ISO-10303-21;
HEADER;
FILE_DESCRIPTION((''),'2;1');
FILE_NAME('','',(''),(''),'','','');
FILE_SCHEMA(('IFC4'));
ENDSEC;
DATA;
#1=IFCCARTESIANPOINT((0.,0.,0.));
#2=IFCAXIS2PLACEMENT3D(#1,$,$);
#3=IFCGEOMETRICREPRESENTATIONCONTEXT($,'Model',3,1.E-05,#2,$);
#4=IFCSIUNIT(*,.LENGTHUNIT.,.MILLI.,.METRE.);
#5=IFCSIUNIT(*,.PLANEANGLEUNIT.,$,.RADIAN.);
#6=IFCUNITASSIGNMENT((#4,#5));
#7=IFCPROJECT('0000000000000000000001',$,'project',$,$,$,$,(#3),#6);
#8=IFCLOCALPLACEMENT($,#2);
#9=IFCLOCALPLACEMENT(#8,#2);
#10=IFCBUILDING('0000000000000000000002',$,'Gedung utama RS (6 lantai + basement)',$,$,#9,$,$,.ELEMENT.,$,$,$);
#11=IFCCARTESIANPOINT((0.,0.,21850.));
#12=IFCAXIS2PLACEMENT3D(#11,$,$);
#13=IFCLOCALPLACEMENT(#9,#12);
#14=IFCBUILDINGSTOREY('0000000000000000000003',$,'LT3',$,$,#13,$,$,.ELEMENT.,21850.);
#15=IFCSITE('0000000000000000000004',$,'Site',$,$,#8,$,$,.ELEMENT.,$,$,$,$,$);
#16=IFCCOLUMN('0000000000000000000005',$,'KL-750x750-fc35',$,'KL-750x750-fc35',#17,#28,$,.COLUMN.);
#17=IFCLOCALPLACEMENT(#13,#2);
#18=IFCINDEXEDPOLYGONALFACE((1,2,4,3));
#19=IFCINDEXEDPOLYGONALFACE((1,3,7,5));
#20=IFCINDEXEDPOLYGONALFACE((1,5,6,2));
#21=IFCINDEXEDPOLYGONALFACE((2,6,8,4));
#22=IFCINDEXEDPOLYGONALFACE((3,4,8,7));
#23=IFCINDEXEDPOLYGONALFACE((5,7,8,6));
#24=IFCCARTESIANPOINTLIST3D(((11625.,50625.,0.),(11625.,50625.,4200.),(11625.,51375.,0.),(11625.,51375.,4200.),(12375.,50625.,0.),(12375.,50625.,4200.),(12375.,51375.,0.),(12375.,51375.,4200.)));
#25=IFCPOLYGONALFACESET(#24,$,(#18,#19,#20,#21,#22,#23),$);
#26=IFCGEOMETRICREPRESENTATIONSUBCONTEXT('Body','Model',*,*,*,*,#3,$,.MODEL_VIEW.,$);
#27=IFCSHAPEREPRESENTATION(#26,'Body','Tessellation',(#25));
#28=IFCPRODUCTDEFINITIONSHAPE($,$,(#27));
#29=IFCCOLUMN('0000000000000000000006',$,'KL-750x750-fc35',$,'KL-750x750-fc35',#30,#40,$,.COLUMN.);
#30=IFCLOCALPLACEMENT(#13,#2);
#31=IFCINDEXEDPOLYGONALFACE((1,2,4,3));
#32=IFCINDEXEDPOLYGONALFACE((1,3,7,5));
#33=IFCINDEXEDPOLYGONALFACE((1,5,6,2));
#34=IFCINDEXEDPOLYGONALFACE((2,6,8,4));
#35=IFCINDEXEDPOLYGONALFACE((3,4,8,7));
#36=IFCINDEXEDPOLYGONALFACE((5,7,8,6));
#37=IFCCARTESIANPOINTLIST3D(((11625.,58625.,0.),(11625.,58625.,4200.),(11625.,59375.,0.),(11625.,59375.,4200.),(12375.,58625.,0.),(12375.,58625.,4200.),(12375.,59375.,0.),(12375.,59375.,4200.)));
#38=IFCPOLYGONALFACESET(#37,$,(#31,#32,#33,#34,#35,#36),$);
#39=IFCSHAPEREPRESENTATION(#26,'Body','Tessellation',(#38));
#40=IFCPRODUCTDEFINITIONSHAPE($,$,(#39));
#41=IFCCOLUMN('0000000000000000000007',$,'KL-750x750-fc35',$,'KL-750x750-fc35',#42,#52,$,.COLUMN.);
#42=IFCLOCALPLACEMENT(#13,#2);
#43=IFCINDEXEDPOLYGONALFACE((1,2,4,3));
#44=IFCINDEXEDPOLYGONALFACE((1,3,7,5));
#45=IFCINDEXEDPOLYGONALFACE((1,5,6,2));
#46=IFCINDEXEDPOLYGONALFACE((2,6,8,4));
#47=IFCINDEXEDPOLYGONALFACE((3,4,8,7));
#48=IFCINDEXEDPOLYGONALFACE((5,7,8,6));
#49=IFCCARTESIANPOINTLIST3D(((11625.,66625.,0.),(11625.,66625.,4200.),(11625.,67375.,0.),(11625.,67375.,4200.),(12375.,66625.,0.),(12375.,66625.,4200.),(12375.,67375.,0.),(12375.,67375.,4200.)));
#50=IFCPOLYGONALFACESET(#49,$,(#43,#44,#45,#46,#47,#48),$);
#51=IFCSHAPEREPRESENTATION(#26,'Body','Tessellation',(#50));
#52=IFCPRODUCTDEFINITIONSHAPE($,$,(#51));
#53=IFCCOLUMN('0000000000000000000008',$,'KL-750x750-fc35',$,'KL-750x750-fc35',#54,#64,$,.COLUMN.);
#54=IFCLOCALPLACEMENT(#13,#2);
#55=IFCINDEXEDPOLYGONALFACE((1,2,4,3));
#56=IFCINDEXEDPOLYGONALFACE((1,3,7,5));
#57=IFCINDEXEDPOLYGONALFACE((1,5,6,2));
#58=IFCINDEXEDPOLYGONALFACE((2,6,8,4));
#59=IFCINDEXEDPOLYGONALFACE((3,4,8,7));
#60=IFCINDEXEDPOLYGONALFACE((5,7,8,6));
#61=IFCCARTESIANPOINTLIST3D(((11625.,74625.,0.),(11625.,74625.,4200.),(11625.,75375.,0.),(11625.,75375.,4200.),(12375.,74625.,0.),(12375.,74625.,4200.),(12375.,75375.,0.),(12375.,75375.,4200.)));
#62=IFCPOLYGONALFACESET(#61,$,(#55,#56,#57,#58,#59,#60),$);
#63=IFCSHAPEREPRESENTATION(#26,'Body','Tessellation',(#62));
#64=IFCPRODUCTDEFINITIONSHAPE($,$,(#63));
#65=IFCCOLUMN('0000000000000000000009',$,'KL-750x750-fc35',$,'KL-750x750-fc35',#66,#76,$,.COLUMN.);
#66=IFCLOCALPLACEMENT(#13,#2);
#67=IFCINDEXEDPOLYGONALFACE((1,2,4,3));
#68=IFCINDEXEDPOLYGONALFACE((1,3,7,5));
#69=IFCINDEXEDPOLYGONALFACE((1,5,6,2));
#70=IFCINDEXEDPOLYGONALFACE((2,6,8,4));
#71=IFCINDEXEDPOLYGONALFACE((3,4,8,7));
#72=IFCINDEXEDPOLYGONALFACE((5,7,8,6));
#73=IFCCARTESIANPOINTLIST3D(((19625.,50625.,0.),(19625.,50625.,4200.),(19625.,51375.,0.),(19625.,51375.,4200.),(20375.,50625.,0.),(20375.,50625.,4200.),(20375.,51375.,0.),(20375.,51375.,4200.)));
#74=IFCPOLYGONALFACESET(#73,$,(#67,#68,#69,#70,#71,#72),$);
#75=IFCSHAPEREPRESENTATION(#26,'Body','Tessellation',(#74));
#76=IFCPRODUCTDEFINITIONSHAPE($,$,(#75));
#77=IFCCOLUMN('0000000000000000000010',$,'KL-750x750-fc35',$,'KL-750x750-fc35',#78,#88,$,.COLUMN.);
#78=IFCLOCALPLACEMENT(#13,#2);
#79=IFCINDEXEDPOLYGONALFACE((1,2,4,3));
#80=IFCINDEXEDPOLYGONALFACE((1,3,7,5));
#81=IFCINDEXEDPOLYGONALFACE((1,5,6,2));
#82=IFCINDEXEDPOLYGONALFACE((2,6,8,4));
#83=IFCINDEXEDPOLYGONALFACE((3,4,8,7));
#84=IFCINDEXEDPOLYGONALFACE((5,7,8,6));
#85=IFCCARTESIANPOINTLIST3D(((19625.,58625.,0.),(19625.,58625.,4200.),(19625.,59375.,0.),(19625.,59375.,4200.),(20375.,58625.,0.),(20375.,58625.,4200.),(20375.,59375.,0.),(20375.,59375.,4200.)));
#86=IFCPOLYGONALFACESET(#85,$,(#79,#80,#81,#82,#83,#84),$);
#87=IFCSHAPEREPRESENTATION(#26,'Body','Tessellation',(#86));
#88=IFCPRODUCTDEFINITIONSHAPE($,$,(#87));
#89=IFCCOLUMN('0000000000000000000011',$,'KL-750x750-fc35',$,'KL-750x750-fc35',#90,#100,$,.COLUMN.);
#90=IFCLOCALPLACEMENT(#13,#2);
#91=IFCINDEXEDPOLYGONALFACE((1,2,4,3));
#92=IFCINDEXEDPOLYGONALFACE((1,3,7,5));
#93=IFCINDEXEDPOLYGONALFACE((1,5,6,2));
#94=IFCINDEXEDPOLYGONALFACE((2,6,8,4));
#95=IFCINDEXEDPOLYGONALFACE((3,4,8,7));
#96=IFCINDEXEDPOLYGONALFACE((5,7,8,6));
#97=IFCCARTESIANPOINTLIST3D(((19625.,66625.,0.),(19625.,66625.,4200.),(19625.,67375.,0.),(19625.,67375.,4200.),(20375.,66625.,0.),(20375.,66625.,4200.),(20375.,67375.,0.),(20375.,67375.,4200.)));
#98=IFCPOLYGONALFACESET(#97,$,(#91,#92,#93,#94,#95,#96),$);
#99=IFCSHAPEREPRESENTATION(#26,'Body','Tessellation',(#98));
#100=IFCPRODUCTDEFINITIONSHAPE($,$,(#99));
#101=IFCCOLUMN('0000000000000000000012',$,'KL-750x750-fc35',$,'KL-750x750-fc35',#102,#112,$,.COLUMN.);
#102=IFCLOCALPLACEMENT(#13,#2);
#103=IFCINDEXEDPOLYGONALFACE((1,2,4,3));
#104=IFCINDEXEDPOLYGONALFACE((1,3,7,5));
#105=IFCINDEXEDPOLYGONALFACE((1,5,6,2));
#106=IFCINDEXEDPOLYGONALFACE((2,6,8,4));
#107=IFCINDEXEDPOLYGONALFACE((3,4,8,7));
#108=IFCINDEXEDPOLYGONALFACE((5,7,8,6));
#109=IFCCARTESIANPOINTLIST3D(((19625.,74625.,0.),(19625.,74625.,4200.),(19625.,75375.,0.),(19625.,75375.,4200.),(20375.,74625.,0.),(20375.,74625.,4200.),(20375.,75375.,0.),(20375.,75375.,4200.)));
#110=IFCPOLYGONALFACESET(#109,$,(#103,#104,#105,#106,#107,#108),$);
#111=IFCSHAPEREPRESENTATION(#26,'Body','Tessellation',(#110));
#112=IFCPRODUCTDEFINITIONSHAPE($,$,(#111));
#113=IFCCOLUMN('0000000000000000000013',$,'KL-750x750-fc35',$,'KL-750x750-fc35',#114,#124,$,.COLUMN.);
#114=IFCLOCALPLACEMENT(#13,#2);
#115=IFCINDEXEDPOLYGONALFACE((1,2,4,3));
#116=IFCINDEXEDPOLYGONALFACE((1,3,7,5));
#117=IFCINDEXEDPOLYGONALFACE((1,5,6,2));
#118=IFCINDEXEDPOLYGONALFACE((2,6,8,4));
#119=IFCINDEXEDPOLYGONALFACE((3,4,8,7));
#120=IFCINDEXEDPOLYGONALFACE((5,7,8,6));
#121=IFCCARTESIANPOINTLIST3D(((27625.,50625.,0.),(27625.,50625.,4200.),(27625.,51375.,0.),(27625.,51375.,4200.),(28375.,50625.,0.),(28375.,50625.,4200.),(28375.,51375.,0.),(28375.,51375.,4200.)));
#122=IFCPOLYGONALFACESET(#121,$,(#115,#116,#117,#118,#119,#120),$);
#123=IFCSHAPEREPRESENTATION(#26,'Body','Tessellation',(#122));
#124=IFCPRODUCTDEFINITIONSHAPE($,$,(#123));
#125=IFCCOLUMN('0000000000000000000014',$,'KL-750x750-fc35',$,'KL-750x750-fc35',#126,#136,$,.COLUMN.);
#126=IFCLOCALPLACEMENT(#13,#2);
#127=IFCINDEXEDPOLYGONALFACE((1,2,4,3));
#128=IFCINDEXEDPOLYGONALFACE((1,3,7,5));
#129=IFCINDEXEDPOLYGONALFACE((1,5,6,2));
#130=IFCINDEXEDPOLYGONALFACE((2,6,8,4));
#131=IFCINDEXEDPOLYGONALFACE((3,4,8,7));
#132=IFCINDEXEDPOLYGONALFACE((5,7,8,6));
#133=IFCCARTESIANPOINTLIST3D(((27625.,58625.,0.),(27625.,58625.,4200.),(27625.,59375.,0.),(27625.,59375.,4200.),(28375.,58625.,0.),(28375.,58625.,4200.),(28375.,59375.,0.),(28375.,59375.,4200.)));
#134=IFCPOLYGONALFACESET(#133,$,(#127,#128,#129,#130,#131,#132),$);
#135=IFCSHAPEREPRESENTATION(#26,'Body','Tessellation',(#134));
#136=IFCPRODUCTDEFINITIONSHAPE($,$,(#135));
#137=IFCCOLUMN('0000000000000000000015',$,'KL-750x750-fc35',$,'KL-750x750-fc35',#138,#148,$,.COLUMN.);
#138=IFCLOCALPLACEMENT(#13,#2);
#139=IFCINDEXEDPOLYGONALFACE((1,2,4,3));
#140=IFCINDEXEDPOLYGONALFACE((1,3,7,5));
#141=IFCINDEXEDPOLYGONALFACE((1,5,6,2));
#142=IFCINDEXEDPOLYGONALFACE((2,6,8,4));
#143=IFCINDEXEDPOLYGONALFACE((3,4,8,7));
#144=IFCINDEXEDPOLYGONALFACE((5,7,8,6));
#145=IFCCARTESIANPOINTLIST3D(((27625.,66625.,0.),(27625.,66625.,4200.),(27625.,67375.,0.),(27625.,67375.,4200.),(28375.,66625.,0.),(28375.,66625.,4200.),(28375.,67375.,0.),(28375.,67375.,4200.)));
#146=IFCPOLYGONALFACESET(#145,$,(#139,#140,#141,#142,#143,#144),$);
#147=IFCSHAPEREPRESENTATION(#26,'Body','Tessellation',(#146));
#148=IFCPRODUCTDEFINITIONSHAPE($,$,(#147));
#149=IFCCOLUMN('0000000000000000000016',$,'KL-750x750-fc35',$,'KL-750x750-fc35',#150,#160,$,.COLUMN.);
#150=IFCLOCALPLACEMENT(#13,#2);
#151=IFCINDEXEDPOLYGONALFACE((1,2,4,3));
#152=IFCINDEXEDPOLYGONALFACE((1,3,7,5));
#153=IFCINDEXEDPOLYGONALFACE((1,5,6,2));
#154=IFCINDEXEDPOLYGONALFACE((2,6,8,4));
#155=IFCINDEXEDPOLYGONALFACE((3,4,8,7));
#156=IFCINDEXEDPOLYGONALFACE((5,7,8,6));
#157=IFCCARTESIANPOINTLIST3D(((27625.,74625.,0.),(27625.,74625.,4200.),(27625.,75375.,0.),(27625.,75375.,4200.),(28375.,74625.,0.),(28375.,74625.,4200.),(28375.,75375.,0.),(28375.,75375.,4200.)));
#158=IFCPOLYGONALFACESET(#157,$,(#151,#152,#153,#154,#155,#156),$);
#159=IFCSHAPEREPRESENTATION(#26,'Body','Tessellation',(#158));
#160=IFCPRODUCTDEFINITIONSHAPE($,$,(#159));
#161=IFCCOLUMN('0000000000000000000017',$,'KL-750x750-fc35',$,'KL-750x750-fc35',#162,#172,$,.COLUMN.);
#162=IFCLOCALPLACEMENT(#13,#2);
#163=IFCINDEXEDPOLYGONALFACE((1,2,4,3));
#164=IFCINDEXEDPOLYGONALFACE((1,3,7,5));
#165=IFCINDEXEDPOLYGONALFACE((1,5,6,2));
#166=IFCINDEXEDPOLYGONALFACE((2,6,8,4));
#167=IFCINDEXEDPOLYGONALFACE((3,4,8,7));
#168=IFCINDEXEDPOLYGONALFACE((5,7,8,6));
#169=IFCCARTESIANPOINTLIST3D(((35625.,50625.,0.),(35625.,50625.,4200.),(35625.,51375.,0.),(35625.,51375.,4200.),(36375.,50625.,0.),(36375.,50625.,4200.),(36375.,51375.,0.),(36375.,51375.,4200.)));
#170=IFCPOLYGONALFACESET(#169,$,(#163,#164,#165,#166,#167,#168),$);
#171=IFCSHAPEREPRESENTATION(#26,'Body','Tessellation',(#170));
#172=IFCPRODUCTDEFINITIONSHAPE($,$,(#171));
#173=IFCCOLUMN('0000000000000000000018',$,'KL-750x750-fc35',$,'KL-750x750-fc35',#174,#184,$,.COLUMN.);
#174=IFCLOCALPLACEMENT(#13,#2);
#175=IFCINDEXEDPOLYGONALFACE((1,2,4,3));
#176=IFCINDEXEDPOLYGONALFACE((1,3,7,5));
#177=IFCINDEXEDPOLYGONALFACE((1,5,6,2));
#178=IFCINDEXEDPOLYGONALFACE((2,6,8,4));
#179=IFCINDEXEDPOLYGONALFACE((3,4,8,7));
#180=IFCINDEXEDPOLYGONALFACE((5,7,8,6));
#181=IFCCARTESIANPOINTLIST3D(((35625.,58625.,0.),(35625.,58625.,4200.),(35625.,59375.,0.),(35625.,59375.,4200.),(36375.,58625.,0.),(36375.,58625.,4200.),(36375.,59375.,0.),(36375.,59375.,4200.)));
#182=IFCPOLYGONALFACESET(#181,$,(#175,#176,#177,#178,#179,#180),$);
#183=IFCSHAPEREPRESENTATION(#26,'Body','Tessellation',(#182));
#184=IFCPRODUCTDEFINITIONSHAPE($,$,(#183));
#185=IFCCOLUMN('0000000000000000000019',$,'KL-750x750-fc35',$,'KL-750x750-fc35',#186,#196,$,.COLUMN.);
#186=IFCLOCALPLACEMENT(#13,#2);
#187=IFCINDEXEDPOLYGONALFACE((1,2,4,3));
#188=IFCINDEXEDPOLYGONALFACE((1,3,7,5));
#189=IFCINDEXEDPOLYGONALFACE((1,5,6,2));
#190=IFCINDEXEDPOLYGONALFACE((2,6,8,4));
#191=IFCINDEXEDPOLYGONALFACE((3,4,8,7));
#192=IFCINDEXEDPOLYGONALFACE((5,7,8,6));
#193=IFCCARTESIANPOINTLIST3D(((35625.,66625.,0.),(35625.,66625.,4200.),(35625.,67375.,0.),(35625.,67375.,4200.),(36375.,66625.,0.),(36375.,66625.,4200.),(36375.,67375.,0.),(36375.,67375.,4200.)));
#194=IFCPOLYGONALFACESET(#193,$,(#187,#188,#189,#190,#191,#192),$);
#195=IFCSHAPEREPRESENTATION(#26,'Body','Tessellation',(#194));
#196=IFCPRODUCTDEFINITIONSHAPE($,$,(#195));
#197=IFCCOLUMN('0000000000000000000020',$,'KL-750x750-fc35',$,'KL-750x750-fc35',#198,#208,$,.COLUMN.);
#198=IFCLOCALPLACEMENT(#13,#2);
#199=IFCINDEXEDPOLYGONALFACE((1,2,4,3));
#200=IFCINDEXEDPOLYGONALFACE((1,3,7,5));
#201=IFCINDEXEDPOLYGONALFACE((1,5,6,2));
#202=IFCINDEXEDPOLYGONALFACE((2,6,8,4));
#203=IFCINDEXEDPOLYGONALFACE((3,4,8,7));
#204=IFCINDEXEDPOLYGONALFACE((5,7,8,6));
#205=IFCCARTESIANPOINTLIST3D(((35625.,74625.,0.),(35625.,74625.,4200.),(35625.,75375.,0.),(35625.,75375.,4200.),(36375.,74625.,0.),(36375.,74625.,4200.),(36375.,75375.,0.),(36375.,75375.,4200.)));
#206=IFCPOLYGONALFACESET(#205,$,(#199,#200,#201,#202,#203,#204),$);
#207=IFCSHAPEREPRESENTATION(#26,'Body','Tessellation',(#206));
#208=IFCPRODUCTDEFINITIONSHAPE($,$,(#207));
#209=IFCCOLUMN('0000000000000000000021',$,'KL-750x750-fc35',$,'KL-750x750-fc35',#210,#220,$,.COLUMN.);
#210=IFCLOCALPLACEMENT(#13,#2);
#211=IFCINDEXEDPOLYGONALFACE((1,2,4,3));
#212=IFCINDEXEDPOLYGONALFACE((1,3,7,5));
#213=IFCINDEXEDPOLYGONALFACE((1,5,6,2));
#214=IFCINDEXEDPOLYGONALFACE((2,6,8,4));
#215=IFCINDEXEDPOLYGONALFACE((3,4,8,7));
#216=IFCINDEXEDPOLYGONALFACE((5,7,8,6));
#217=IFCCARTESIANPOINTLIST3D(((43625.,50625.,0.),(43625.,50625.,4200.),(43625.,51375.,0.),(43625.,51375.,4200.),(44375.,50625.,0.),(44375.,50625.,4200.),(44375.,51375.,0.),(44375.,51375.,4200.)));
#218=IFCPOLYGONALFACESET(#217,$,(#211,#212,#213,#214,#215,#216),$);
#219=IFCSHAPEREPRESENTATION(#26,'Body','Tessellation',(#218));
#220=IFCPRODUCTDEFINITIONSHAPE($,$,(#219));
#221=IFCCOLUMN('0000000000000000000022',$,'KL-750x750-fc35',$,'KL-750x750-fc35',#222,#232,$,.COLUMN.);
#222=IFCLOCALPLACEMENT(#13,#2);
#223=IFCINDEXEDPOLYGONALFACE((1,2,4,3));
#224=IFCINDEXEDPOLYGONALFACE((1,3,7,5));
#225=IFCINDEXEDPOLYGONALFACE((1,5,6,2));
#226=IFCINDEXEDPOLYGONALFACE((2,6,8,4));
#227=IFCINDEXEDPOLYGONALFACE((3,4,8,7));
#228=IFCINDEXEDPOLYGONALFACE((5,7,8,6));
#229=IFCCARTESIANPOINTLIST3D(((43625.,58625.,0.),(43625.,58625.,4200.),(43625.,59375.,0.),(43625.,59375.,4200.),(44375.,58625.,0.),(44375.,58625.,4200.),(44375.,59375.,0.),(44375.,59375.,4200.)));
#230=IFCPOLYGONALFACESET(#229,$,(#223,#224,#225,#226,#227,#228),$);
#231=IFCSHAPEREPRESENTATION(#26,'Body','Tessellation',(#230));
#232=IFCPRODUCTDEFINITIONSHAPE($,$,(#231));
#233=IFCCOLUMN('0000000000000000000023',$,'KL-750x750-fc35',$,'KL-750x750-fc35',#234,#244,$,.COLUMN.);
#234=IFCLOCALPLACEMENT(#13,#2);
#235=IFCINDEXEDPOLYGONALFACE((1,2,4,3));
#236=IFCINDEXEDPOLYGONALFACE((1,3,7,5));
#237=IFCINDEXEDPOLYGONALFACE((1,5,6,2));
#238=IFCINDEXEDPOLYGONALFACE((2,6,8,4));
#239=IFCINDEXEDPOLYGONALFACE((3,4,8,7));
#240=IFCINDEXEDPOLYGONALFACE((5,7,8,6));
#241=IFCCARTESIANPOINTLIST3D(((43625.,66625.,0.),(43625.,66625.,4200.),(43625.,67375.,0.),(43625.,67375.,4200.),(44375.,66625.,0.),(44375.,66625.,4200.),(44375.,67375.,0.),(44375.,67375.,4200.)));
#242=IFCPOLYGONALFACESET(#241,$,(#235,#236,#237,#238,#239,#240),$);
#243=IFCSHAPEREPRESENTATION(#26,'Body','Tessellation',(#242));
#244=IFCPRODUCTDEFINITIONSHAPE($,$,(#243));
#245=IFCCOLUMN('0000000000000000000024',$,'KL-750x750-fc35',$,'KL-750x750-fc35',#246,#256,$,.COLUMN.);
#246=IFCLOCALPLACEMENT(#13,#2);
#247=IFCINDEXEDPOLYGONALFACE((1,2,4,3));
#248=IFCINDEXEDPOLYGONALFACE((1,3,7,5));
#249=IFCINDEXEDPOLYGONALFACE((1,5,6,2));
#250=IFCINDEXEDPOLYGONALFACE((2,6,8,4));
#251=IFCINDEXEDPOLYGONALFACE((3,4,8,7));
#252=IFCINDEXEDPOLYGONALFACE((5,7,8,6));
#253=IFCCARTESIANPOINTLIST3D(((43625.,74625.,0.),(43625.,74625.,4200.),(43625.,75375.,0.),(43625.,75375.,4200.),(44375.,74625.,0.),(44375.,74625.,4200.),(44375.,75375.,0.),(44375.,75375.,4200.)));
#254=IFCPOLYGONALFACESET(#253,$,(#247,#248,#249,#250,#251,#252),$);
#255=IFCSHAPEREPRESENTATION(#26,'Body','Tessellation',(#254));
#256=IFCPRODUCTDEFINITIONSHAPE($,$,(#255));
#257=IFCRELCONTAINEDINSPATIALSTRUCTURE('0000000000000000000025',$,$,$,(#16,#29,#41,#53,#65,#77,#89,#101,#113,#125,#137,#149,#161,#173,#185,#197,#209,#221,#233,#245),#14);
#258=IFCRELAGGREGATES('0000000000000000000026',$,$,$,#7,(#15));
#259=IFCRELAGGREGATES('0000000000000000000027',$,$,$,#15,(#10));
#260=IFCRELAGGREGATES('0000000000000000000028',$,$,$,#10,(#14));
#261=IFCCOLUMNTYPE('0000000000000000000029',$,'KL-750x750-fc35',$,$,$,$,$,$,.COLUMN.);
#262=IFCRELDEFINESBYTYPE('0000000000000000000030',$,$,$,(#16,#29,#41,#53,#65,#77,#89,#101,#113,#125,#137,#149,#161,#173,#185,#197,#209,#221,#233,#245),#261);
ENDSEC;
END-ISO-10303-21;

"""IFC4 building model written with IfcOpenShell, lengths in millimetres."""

from ifc_helpers import new_model, si_unit, frame, origin, origin_2d, place, context, subcontext, project, spatial, rectangle, extrude, material_profile, profile_set, profile_usage, type_object, element, save


model = new_model("IFC4")

# Units and contexts
model_context = context("Model", 3, precision=1e-05, world=origin())
body_context = subcontext(model_context, "Body", "Model", "MODEL_VIEW")
ifc_project = project(units=[si_unit("LENGTHUNIT", "METRE", prefix="MILLI"), si_unit("PLANEANGLEUNIT", "RADIAN")], contexts=[model_context])

# Site, building, storey
site_placement = place(None, origin())
site = spatial("IfcSite", under=ifc_project, at=site_placement, Name="Site", CompositionType="ELEMENT")
building_placement = place(site_placement, origin())
building = spatial("IfcBuilding", under=site, at=building_placement, Name="Gedung utama RS (6 lantai + basement)", CompositionType="ELEMENT")
storey_placement = place(building_placement, frame((0.0, 0.0, 21850.0)))
storey = spatial("IfcBuildingStorey", under=building, at=storey_placement, Name="LT3", CompositionType="ELEMENT", Elevation=21850.0)

# Columns
ifc_material_profile_1 = material_profile(None, rectangle(XDim=750.0, YDim=750.0, at=origin_2d()), Name="KL-750x750-fc35")
ifc_profile_set_1 = profile_set([ifc_material_profile_1], Name="KL-750x750-fc35")
ifc_profile_usage_1 = profile_usage(ifc_profile_set_1, cardinal=5)
column_type = type_object("IfcColumnType", Name="KL-750x750-fc35", PredefinedType="COLUMN", material=ifc_profile_set_1)
for number, where, z_axis, x_axis, name in (
    (1, (12000.0, 51000.0, 0.0), (0.0, 0.0, 1.0), (1.0, 0.0, 0.0), "KL-750x750-fc35"),
    (2, (12000.0, 59000.0, 0.0), (0.0, 0.0, 1.0), (1.0, 0.0, 0.0), "KL-750x750-fc35"),
    (3, (12000.0, 67000.0, 0.0), (0.0, 0.0, 1.0), (1.0, 0.0, 0.0), "KL-750x750-fc35"),
    (4, (12000.0, 75000.0, 0.0), (0.0, 0.0, 1.0), (1.0, 0.0, 0.0), "KL-750x750-fc35"),
    (5, (20000.0, 51000.0, 0.0), (0.0, 0.0, 1.0), (1.0, 0.0, 0.0), "KL-750x750-fc35"),
    (6, (20000.0, 59000.0, 0.0), (0.0, 0.0, 1.0), (1.0, 0.0, 0.0), "KL-750x750-fc35"),
    (7, (20000.0, 67000.0, 0.0), (0.0, 0.0, 1.0), (1.0, 0.0, 0.0), "KL-750x750-fc35"),
    (8, (20000.0, 75000.0, 0.0), (0.0, 0.0, 1.0), (1.0, 0.0, 0.0), "KL-750x750-fc35"),
    (9, (28000.0, 51000.0, 0.0), (0.0, 0.0, 1.0), (1.0, 0.0, 0.0), "KL-750x750-fc35"),
    (10, (28000.0, 59000.0, 0.0), (0.0, 0.0, 1.0), (1.0, 0.0, 0.0), "KL-750x750-fc35"),
    (11, (28000.0, 67000.0, 0.0), (0.0, 0.0, 1.0), (1.0, 0.0, 0.0), "KL-750x750-fc35"),
    (12, (28000.0, 75000.0, 0.0), (0.0, 0.0, 1.0), (1.0, 0.0, 0.0), "KL-750x750-fc35"),
    (13, (36000.0, 51000.0, 0.0), (0.0, 0.0, 1.0), (1.0, 0.0, 0.0), "KL-750x750-fc35"),
    (14, (36000.0, 59000.0, 0.0), (0.0, 0.0, 1.0), (1.0, 0.0, 0.0), "KL-750x750-fc35"),
    (15, (36000.0, 67000.0, 0.0), (0.0, 0.0, 1.0), (1.0, 0.0, 0.0), "KL-750x750-fc35"),
    (16, (36000.0, 75000.0, 0.0), (0.0, 0.0, 1.0), (1.0, 0.0, 0.0), "KL-750x750-fc35"),
    (17, (44000.0, 51000.0, 0.0), (0.0, 0.0, 1.0), (1.0, 0.0, 0.0), "KL-750x750-fc35"),
    (18, (44000.0, 59000.0, 0.0), (0.0, 0.0, 1.0), (1.0, 0.0, 0.0), "KL-750x750-fc35"),
    (19, (44000.0, 67000.0, 0.0), (0.0, 0.0, 1.0), (1.0, 0.0, 0.0), "KL-750x750-fc35"),
    (20, (44000.0, 75000.0, 0.0), (0.0, 0.0, 1.0), (1.0, 0.0, 0.0), "KL-750x750-fc35"),
):
    element("IfcColumn", number, at=place(storey_placement, frame(where, z_axis=z_axis, x_axis=x_axis)), inside=storey, type_object=column_type, material=ifc_profile_usage_1, Name=name, ObjectType="KL-750x750-fc35", PredefinedType="COLUMN", context=body_context, shape_type="SweptSolid", body=[
        extrude(rectangle(XDim=750.0, YDim=750.0, at=origin_2d()), origin(), (0.0, 0.0, 1.0), 4200.0),
    ])

save(model, "model.ifc")
